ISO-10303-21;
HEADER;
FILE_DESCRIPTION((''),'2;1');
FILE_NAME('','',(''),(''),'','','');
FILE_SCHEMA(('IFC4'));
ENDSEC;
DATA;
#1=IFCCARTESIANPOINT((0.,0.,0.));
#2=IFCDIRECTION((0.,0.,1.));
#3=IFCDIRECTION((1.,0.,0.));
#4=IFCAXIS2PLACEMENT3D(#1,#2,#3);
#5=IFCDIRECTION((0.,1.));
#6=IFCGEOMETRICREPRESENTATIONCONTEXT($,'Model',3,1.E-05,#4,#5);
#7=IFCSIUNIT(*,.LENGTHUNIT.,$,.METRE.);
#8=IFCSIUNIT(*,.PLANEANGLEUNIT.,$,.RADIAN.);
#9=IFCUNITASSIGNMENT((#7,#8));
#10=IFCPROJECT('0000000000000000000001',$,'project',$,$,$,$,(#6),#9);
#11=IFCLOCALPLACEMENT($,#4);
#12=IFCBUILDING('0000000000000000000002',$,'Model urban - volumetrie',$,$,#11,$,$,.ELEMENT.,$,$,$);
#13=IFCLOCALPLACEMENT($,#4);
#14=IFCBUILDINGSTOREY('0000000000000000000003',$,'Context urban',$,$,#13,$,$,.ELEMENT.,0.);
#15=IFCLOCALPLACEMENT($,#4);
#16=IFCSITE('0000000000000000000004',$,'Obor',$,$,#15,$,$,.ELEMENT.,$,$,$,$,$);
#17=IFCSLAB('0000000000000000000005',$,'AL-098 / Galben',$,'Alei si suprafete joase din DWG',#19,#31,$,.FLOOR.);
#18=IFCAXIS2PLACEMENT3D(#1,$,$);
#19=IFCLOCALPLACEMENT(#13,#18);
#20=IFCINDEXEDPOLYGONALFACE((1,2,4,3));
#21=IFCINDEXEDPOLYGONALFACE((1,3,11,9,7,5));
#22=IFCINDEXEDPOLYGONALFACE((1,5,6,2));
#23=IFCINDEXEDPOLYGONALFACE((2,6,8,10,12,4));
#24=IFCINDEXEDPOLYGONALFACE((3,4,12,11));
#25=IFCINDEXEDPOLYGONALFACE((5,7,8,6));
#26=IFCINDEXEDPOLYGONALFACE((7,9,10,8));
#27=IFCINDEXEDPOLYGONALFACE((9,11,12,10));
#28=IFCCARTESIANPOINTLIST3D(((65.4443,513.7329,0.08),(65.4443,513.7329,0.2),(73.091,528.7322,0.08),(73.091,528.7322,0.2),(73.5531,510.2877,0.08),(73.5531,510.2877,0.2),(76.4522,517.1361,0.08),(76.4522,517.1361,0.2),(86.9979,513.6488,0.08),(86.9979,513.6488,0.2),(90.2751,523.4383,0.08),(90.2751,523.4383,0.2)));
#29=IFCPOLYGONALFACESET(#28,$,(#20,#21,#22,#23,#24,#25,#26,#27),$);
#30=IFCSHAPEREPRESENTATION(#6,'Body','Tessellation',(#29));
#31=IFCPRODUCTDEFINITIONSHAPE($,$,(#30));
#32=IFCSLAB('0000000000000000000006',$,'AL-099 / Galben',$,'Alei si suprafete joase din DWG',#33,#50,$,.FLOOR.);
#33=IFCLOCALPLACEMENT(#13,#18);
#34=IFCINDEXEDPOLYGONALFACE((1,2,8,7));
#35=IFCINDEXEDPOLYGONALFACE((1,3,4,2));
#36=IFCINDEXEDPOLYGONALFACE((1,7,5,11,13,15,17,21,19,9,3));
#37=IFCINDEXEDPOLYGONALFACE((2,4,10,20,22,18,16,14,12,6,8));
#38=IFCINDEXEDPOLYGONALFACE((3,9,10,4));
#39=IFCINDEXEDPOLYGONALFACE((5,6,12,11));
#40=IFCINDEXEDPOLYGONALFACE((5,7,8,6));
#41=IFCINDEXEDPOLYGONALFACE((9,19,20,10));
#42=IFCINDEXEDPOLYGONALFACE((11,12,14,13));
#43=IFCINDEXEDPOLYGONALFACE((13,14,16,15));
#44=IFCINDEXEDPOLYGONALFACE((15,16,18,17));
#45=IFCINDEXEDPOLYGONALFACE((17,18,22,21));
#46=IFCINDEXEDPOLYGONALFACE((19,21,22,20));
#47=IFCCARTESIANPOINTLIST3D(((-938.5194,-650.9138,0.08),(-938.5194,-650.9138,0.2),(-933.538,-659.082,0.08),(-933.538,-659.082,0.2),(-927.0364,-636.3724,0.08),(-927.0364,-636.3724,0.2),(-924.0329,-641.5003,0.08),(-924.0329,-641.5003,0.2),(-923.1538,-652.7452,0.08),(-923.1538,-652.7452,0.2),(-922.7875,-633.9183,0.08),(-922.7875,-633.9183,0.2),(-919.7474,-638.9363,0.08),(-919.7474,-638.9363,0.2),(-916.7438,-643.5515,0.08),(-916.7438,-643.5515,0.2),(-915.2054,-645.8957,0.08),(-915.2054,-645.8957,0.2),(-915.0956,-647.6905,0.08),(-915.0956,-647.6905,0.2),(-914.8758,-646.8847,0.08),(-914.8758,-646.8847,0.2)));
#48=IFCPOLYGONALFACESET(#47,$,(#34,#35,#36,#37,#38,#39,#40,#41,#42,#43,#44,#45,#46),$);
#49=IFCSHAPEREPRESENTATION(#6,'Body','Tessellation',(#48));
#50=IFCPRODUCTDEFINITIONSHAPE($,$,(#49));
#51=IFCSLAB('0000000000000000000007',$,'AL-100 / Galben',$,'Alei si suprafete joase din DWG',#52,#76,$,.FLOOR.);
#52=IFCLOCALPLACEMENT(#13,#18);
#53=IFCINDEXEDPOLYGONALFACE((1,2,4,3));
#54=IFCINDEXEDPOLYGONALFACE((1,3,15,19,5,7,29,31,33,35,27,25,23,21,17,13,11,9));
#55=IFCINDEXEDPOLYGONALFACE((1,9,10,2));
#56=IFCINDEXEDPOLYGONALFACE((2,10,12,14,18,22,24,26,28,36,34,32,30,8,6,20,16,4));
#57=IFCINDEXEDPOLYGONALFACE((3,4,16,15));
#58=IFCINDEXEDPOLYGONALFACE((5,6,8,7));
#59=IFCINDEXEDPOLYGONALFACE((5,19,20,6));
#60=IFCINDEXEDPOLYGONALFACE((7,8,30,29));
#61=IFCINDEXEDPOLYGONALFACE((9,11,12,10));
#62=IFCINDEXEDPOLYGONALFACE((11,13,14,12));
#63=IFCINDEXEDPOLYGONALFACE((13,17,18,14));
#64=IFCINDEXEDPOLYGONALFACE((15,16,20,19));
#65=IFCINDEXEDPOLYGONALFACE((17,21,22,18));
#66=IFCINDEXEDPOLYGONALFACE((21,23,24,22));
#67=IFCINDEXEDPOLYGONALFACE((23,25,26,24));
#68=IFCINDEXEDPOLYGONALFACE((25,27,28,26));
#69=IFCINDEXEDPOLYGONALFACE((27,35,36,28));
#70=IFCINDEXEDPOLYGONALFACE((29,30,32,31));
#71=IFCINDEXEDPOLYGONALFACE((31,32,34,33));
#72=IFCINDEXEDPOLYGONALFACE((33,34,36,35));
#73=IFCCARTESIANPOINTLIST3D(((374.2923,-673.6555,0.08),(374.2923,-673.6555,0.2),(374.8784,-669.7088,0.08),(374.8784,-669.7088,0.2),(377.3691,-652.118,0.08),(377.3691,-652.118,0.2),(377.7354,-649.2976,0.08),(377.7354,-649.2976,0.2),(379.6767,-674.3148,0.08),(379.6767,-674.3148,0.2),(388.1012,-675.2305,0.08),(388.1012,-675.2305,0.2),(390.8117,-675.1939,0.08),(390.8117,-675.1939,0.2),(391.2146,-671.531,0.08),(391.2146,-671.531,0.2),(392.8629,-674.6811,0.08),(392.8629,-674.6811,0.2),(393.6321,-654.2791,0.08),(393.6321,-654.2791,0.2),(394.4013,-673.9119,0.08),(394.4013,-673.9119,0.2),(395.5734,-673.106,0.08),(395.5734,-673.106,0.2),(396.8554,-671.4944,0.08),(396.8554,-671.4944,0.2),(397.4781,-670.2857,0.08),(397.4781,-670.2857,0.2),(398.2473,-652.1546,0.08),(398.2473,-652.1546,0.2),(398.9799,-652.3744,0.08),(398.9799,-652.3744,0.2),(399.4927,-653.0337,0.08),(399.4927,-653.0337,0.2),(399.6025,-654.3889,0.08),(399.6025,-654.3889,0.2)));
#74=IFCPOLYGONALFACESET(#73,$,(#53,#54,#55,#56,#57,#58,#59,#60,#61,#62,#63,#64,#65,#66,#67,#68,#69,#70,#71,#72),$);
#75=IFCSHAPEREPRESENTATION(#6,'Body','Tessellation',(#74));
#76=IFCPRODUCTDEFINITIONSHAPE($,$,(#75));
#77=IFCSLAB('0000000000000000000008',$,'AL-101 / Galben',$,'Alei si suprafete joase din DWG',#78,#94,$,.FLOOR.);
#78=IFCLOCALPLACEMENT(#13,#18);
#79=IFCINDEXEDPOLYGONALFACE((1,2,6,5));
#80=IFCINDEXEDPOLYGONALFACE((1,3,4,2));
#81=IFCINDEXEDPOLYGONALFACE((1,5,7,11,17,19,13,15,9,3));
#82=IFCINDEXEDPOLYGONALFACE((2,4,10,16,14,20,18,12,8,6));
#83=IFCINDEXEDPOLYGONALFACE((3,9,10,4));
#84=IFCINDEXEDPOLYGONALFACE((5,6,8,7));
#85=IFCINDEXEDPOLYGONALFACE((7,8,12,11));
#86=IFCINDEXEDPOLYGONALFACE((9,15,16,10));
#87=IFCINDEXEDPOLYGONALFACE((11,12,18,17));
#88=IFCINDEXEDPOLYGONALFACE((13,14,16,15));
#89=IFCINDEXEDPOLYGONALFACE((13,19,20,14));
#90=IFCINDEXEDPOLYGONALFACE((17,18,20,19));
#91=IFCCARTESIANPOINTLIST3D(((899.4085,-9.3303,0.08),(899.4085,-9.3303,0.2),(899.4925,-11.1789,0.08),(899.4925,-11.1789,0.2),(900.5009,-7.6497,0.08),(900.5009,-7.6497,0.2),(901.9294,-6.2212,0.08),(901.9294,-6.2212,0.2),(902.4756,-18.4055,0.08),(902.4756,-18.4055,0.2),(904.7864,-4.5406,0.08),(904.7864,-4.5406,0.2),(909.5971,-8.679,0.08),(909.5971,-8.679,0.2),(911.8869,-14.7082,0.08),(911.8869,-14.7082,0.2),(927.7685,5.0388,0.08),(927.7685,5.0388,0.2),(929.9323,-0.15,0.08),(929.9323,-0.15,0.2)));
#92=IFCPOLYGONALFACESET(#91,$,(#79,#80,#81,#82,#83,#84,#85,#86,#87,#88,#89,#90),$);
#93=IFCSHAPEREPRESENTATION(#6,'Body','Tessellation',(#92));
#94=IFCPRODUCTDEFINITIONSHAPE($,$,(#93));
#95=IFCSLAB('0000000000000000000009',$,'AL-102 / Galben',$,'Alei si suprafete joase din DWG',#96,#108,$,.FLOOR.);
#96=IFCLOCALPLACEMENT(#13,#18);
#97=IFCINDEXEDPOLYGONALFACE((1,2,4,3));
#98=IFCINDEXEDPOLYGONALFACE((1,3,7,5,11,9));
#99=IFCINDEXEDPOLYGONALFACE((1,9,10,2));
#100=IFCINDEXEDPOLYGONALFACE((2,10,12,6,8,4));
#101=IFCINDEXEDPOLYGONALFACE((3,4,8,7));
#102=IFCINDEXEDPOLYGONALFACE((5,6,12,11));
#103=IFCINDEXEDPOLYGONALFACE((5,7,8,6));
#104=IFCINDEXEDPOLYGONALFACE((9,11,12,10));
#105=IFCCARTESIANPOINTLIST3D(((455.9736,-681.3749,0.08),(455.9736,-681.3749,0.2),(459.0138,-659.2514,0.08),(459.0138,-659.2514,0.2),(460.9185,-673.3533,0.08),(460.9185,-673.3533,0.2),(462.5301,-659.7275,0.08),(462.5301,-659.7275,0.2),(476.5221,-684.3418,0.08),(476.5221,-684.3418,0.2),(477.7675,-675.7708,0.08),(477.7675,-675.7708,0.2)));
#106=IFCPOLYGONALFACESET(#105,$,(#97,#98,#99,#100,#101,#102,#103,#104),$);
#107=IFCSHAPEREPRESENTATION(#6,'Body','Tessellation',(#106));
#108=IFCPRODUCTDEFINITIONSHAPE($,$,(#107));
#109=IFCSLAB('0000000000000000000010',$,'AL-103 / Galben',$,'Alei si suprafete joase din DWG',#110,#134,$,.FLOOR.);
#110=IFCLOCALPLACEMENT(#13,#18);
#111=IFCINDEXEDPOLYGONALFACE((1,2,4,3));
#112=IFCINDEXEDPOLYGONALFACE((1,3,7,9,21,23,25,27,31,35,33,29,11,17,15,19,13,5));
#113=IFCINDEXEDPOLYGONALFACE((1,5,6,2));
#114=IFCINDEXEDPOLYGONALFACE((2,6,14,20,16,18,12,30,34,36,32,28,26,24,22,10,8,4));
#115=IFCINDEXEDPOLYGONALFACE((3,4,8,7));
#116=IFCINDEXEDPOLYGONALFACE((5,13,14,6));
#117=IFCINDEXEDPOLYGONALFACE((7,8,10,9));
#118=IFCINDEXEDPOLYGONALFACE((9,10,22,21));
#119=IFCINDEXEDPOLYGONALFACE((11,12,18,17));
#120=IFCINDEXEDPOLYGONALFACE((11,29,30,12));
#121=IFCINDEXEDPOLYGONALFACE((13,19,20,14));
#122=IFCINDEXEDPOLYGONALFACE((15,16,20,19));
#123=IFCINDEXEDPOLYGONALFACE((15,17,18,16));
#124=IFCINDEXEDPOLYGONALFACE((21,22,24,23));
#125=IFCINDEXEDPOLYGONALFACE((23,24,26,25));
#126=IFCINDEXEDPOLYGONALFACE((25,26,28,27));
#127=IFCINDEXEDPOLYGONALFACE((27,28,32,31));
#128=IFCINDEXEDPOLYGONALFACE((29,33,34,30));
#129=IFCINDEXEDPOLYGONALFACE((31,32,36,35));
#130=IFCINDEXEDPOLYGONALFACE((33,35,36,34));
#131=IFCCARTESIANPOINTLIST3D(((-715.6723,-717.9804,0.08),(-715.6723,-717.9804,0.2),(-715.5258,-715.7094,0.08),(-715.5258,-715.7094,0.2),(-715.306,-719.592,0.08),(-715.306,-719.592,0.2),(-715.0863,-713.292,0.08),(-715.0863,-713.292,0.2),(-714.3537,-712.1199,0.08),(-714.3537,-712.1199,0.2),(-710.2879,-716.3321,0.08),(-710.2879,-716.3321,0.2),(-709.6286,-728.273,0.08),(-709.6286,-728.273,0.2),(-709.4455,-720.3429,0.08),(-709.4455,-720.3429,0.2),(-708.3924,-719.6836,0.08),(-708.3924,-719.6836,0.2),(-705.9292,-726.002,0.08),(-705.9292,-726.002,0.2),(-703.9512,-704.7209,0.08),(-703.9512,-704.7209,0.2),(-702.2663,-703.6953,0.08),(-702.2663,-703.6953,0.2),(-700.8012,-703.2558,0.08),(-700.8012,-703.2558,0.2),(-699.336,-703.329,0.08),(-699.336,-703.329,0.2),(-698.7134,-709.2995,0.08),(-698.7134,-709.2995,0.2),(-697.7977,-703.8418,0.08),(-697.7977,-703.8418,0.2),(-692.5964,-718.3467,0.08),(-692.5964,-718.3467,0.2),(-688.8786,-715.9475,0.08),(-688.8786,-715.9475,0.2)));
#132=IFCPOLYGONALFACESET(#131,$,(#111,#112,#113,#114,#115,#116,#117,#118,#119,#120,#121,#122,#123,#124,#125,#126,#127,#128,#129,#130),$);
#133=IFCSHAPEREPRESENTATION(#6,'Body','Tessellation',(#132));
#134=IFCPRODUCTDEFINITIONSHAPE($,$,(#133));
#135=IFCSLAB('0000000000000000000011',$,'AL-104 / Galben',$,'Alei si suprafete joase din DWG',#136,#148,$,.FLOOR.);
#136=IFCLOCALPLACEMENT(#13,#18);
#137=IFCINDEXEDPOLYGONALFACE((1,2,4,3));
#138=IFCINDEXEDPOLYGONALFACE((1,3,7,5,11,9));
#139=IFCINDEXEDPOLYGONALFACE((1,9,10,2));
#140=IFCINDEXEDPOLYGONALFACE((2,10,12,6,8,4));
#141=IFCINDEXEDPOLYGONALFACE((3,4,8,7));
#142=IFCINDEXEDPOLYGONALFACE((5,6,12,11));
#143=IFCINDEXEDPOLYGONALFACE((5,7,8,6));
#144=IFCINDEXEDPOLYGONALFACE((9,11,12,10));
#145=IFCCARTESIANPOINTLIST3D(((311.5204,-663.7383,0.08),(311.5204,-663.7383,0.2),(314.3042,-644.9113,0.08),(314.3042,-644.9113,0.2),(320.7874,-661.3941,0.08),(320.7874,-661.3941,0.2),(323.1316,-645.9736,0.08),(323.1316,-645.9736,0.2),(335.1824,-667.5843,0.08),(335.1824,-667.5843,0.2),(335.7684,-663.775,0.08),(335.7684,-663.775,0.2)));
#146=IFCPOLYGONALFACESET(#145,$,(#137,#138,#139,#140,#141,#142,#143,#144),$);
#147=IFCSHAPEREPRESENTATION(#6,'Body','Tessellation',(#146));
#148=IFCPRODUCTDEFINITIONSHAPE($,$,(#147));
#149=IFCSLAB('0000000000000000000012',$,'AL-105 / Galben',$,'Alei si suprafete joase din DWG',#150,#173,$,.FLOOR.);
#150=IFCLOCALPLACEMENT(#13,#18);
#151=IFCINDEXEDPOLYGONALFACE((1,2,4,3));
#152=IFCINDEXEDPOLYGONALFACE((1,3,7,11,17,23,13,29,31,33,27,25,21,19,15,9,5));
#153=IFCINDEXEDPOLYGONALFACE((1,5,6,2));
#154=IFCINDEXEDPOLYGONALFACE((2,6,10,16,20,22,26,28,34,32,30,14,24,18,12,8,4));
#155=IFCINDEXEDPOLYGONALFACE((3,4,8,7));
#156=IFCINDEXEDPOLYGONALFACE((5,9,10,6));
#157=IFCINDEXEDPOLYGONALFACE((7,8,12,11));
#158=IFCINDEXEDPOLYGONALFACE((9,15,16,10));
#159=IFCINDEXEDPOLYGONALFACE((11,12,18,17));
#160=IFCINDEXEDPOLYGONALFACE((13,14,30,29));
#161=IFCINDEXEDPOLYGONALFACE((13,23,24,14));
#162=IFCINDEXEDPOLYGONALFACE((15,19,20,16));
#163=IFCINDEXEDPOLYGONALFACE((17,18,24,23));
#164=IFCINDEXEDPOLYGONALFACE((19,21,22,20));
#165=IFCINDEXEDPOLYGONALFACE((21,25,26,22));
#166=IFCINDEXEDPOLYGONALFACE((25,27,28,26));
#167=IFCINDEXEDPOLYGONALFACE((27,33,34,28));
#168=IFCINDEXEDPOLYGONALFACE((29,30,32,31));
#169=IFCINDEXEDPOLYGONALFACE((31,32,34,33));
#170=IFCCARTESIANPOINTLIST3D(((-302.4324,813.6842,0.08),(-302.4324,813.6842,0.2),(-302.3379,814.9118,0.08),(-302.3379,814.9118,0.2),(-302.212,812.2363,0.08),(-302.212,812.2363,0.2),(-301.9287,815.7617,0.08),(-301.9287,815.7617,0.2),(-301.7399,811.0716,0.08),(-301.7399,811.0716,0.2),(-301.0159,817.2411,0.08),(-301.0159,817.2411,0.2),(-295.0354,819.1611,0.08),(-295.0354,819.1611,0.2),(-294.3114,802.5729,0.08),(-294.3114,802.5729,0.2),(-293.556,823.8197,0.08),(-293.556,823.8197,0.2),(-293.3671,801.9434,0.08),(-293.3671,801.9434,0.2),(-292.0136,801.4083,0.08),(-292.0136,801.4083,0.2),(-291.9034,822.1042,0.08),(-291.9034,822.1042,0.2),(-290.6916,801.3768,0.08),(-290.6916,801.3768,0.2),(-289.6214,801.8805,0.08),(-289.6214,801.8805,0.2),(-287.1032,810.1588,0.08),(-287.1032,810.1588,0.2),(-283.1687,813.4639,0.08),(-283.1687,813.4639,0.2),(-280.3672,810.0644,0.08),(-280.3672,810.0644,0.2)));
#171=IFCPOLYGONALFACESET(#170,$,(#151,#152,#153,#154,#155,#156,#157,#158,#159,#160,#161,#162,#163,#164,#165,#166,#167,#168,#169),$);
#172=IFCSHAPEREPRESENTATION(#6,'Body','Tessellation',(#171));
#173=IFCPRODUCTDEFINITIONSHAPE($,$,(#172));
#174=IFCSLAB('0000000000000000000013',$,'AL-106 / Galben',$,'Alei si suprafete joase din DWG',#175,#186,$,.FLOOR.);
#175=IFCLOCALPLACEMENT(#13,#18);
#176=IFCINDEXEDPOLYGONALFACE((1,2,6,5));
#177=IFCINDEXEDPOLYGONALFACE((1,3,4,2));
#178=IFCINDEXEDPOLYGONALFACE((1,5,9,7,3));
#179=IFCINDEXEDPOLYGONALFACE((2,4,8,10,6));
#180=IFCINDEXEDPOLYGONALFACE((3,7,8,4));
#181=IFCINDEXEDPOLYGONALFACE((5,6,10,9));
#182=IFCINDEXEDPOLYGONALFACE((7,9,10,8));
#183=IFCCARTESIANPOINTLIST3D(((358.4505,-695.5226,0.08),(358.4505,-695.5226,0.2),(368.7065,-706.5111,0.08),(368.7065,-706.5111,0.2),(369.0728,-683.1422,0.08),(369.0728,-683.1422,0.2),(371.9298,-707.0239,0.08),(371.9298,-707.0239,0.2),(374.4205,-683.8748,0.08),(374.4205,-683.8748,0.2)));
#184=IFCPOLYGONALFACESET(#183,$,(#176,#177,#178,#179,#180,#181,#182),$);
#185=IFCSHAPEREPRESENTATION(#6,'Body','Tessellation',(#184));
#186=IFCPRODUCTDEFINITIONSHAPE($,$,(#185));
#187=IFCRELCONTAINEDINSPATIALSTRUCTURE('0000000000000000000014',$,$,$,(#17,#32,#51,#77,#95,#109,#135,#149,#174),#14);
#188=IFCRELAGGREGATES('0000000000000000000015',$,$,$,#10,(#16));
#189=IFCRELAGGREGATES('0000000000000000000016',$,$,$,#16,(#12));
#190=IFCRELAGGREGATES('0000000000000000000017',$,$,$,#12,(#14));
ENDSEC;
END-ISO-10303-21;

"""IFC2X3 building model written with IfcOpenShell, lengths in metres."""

from ifc_helpers import new_model, si_unit, direction, frame, origin_with_axes, place, context, project, spatial, polyline, outline, extrude, element, save


model = new_model("IFC2X3")

# Units and contexts
model_context = context("Model", 3, precision=1e-05, world=origin_with_axes(), true_north=direction((0.0, 1.0)))
ifc_project = project(units=[si_unit("LENGTHUNIT", "METRE"), si_unit("PLANEANGLEUNIT", "RADIAN")], contexts=[model_context])

# Site, building, storey
site_placement = place(None, origin_with_axes())
site = spatial("IfcSite", under=ifc_project, at=site_placement, Name="Obor", CompositionType="ELEMENT")
building_placement = place(None, origin_with_axes())
building = spatial("IfcBuilding", under=site, at=building_placement, Name="Model urban - volumetrie", CompositionType="ELEMENT")
storey_placement = place(None, origin_with_axes())
storey = spatial("IfcBuildingStorey", under=building, at=storey_placement, Name="Context urban", CompositionType="ELEMENT", Elevation=0.0)

# Slabs
slab_1_placement = place(None, origin_with_axes())
element("IfcSlab", 1, at=slab_1_placement, inside=storey, Name="AL-098 / Galben", ObjectType="Alei si suprafete joase din DWG", PredefinedType="FLOOR", context=model_context, shape_type="SweptSolid", body=[
    extrude(outline(polyline([(76.4522, 517.1361), (86.9979, 513.6488), (90.2751, 523.4383), (73.091, 528.7322), (65.4443, 513.7329), (73.5531, 510.2877), (76.4522, 517.1361)])), frame((0.0, 0.0, 0.08), z_axis=(0.0, 0.0, 1.0), x_axis=(1.0, 0.0, 0.0)), (0.0, 0.0, 1.0), 0.12),
])
slab_2_placement = place(None, origin_with_axes())
element("IfcSlab", 2, at=slab_2_placement, inside=storey, Name="AL-099 / Galben", ObjectType="Alei si suprafete joase din DWG", PredefinedType="FLOOR", context=model_context, shape_type="SweptSolid", body=[
    extrude(outline(polyline([(-916.7438, -643.5515), (-919.7474, -638.9363), (-922.7875, -633.9183), (-927.0364, -636.3724), (-924.0329, -641.5003), (-938.5194, -650.9138), (-933.538, -659.082), (-923.1538, -652.7452), (-915.0956, -647.6905), (-914.8758, -646.8847), (-915.2054, -645.8957), (-916.7438, -643.5515)])), frame((0.0, 0.0, 0.08), z_axis=(0.0, 0.0, 1.0), x_axis=(1.0, 0.0, 0.0)), (0.0, 0.0, 1.0), 0.12),
])
slab_3_placement = place(None, origin_with_axes())
element("IfcSlab", 3, at=slab_3_placement, inside=storey, Name="AL-100 / Galben", ObjectType="Alei si suprafete joase din DWG", PredefinedType="FLOOR", context=model_context, shape_type="SweptSolid", body=[
    extrude(outline(polyline([(398.2473, -652.1546), (377.7354, -649.2976), (377.3691, -652.118), (393.6321, -654.2791), (391.2146, -671.531), (374.8784, -669.7088), (374.2923, -673.6555), (379.6767, -674.3148), (388.1012, -675.2305), (390.8117, -675.1939), (392.8629, -674.6811), (394.4013, -673.9119), (395.5734, -673.106), (396.8554, -671.4944), (397.4781, -670.2857), (399.6025, -654.3889), (399.4927, -653.0337), (398.9799, -652.3744), (398.2473, -652.1546)])), frame((0.0, 0.0, 0.08), z_axis=(0.0, 0.0, 1.0), x_axis=(1.0, 0.0, 0.0)), (0.0, 0.0, 1.0), 0.12),
])
slab_4_placement = place(None, origin_with_axes())
element("IfcSlab", 4, at=slab_4_placement, inside=storey, Name="AL-101 / Galben", ObjectType="Alei si suprafete joase din DWG", PredefinedType="FLOOR", context=model_context, shape_type="SweptSolid", body=[
    extrude(outline(polyline([(904.7864, -4.5406), (901.9294, -6.2212), (900.5009, -7.6497), (899.4085, -9.3303), (899.4925, -11.1789), (902.4756, -18.4055), (911.8869, -14.7082), (909.5971, -8.679), (929.9323, -0.15), (927.7685, 5.0388), (904.7864, -4.5406)])), frame((0.0, 0.0, 0.08), z_axis=(0.0, 0.0, 1.0), x_axis=(1.0, 0.0, 0.0)), (0.0, 0.0, 1.0), 0.12),
])
slab_5_placement = place(None, origin_with_axes())
element("IfcSlab", 5, at=slab_5_placement, inside=storey, Name="AL-102 / Galben", ObjectType="Alei si suprafete joase din DWG", PredefinedType="FLOOR", context=model_context, shape_type="SweptSolid", body=[
    extrude(outline(polyline([(459.0138, -659.2514), (455.9736, -681.3749), (476.5221, -684.3418), (477.7675, -675.7708), (460.9185, -673.3533), (462.5301, -659.7275), (459.0138, -659.2514)])), frame((0.0, 0.0, 0.08), z_axis=(0.0, 0.0, 1.0), x_axis=(1.0, 0.0, 0.0)), (0.0, 0.0, 1.0), 0.12),
])
slab_6_placement = place(None, origin_with_axes())
element("IfcSlab", 6, at=slab_6_placement, inside=storey, Name="AL-103 / Galben", ObjectType="Alei si suprafete joase din DWG", PredefinedType="FLOOR", context=model_context, shape_type="SweptSolid", body=[
    extrude(outline(polyline([(-715.0863, -713.292), (-715.5258, -715.7094), (-715.6723, -717.9804), (-715.306, -719.592), (-709.6286, -728.273), (-705.9292, -726.002), (-709.4455, -720.3429), (-708.3924, -719.6836), (-710.2879, -716.3321), (-698.7134, -709.2995), (-692.5964, -718.3467), (-688.8786, -715.9475), (-697.7977, -703.8418), (-699.336, -703.329), (-700.8012, -703.2558), (-702.2663, -703.6953), (-703.9512, -704.7209), (-714.3537, -712.1199), (-715.0863, -713.292)])), frame((0.0, 0.0, 0.08), z_axis=(0.0, 0.0, 1.0), x_axis=(1.0, 0.0, 0.0)), (0.0, 0.0, 1.0), 0.12),
])
slab_7_placement = place(None, origin_with_axes())
element("IfcSlab", 7, at=slab_7_placement, inside=storey, Name="AL-104 / Galben", ObjectType="Alei si suprafete joase din DWG", PredefinedType="FLOOR", context=model_context, shape_type="SweptSolid", body=[
    extrude(outline(polyline([(311.5204, -663.7383), (335.1824, -667.5843), (335.7684, -663.775), (320.7874, -661.3941), (323.1316, -645.9736), (314.3042, -644.9113), (311.5204, -663.7383)])), frame((0.0, 0.0, 0.08), z_axis=(0.0, 0.0, 1.0), x_axis=(1.0, 0.0, 0.0)), (0.0, 0.0, 1.0), 0.12),
])
slab_8_placement = place(None, origin_with_axes())
element("IfcSlab", 8, at=slab_8_placement, inside=storey, Name="AL-105 / Galben", ObjectType="Alei si suprafete joase din DWG", PredefinedType="FLOOR", context=model_context, shape_type="SweptSolid", body=[
    extrude(outline(polyline([(-289.6214, 801.8805), (-280.3672, 810.0644), (-283.1687, 813.4639), (-287.1032, 810.1588), (-295.0354, 819.1611), (-291.9034, 822.1042), (-293.556, 823.8197), (-301.0159, 817.2411), (-301.9287, 815.7617), (-302.3379, 814.9118), (-302.4324, 813.6842), (-302.212, 812.2363), (-301.7399, 811.0716), (-294.3114, 802.5729), (-293.3671, 801.9434), (-292.0136, 801.4083), (-290.6916, 801.3768), (-289.6214, 801.8805)])), frame((0.0, 0.0, 0.08), z_axis=(0.0, 0.0, 1.0), x_axis=(1.0, 0.0, 0.0)), (0.0, 0.0, 1.0), 0.12),
])
slab_9_placement = place(None, origin_with_axes())
element("IfcSlab", 9, at=slab_9_placement, inside=storey, Name="AL-106 / Galben", ObjectType="Alei si suprafete joase din DWG", PredefinedType="FLOOR", context=model_context, shape_type="SweptSolid", body=[
    extrude(outline(polyline([(358.4505, -695.5226), (368.7065, -706.5111), (371.9298, -707.0239), (374.4205, -683.8748), (369.0728, -683.1422), (358.4505, -695.5226)])), frame((0.0, 0.0, 0.08), z_axis=(0.0, 0.0, 1.0), x_axis=(1.0, 0.0, 0.0)), (0.0, 0.0, 1.0), 0.12),
])

save(model, "model.ifc")
